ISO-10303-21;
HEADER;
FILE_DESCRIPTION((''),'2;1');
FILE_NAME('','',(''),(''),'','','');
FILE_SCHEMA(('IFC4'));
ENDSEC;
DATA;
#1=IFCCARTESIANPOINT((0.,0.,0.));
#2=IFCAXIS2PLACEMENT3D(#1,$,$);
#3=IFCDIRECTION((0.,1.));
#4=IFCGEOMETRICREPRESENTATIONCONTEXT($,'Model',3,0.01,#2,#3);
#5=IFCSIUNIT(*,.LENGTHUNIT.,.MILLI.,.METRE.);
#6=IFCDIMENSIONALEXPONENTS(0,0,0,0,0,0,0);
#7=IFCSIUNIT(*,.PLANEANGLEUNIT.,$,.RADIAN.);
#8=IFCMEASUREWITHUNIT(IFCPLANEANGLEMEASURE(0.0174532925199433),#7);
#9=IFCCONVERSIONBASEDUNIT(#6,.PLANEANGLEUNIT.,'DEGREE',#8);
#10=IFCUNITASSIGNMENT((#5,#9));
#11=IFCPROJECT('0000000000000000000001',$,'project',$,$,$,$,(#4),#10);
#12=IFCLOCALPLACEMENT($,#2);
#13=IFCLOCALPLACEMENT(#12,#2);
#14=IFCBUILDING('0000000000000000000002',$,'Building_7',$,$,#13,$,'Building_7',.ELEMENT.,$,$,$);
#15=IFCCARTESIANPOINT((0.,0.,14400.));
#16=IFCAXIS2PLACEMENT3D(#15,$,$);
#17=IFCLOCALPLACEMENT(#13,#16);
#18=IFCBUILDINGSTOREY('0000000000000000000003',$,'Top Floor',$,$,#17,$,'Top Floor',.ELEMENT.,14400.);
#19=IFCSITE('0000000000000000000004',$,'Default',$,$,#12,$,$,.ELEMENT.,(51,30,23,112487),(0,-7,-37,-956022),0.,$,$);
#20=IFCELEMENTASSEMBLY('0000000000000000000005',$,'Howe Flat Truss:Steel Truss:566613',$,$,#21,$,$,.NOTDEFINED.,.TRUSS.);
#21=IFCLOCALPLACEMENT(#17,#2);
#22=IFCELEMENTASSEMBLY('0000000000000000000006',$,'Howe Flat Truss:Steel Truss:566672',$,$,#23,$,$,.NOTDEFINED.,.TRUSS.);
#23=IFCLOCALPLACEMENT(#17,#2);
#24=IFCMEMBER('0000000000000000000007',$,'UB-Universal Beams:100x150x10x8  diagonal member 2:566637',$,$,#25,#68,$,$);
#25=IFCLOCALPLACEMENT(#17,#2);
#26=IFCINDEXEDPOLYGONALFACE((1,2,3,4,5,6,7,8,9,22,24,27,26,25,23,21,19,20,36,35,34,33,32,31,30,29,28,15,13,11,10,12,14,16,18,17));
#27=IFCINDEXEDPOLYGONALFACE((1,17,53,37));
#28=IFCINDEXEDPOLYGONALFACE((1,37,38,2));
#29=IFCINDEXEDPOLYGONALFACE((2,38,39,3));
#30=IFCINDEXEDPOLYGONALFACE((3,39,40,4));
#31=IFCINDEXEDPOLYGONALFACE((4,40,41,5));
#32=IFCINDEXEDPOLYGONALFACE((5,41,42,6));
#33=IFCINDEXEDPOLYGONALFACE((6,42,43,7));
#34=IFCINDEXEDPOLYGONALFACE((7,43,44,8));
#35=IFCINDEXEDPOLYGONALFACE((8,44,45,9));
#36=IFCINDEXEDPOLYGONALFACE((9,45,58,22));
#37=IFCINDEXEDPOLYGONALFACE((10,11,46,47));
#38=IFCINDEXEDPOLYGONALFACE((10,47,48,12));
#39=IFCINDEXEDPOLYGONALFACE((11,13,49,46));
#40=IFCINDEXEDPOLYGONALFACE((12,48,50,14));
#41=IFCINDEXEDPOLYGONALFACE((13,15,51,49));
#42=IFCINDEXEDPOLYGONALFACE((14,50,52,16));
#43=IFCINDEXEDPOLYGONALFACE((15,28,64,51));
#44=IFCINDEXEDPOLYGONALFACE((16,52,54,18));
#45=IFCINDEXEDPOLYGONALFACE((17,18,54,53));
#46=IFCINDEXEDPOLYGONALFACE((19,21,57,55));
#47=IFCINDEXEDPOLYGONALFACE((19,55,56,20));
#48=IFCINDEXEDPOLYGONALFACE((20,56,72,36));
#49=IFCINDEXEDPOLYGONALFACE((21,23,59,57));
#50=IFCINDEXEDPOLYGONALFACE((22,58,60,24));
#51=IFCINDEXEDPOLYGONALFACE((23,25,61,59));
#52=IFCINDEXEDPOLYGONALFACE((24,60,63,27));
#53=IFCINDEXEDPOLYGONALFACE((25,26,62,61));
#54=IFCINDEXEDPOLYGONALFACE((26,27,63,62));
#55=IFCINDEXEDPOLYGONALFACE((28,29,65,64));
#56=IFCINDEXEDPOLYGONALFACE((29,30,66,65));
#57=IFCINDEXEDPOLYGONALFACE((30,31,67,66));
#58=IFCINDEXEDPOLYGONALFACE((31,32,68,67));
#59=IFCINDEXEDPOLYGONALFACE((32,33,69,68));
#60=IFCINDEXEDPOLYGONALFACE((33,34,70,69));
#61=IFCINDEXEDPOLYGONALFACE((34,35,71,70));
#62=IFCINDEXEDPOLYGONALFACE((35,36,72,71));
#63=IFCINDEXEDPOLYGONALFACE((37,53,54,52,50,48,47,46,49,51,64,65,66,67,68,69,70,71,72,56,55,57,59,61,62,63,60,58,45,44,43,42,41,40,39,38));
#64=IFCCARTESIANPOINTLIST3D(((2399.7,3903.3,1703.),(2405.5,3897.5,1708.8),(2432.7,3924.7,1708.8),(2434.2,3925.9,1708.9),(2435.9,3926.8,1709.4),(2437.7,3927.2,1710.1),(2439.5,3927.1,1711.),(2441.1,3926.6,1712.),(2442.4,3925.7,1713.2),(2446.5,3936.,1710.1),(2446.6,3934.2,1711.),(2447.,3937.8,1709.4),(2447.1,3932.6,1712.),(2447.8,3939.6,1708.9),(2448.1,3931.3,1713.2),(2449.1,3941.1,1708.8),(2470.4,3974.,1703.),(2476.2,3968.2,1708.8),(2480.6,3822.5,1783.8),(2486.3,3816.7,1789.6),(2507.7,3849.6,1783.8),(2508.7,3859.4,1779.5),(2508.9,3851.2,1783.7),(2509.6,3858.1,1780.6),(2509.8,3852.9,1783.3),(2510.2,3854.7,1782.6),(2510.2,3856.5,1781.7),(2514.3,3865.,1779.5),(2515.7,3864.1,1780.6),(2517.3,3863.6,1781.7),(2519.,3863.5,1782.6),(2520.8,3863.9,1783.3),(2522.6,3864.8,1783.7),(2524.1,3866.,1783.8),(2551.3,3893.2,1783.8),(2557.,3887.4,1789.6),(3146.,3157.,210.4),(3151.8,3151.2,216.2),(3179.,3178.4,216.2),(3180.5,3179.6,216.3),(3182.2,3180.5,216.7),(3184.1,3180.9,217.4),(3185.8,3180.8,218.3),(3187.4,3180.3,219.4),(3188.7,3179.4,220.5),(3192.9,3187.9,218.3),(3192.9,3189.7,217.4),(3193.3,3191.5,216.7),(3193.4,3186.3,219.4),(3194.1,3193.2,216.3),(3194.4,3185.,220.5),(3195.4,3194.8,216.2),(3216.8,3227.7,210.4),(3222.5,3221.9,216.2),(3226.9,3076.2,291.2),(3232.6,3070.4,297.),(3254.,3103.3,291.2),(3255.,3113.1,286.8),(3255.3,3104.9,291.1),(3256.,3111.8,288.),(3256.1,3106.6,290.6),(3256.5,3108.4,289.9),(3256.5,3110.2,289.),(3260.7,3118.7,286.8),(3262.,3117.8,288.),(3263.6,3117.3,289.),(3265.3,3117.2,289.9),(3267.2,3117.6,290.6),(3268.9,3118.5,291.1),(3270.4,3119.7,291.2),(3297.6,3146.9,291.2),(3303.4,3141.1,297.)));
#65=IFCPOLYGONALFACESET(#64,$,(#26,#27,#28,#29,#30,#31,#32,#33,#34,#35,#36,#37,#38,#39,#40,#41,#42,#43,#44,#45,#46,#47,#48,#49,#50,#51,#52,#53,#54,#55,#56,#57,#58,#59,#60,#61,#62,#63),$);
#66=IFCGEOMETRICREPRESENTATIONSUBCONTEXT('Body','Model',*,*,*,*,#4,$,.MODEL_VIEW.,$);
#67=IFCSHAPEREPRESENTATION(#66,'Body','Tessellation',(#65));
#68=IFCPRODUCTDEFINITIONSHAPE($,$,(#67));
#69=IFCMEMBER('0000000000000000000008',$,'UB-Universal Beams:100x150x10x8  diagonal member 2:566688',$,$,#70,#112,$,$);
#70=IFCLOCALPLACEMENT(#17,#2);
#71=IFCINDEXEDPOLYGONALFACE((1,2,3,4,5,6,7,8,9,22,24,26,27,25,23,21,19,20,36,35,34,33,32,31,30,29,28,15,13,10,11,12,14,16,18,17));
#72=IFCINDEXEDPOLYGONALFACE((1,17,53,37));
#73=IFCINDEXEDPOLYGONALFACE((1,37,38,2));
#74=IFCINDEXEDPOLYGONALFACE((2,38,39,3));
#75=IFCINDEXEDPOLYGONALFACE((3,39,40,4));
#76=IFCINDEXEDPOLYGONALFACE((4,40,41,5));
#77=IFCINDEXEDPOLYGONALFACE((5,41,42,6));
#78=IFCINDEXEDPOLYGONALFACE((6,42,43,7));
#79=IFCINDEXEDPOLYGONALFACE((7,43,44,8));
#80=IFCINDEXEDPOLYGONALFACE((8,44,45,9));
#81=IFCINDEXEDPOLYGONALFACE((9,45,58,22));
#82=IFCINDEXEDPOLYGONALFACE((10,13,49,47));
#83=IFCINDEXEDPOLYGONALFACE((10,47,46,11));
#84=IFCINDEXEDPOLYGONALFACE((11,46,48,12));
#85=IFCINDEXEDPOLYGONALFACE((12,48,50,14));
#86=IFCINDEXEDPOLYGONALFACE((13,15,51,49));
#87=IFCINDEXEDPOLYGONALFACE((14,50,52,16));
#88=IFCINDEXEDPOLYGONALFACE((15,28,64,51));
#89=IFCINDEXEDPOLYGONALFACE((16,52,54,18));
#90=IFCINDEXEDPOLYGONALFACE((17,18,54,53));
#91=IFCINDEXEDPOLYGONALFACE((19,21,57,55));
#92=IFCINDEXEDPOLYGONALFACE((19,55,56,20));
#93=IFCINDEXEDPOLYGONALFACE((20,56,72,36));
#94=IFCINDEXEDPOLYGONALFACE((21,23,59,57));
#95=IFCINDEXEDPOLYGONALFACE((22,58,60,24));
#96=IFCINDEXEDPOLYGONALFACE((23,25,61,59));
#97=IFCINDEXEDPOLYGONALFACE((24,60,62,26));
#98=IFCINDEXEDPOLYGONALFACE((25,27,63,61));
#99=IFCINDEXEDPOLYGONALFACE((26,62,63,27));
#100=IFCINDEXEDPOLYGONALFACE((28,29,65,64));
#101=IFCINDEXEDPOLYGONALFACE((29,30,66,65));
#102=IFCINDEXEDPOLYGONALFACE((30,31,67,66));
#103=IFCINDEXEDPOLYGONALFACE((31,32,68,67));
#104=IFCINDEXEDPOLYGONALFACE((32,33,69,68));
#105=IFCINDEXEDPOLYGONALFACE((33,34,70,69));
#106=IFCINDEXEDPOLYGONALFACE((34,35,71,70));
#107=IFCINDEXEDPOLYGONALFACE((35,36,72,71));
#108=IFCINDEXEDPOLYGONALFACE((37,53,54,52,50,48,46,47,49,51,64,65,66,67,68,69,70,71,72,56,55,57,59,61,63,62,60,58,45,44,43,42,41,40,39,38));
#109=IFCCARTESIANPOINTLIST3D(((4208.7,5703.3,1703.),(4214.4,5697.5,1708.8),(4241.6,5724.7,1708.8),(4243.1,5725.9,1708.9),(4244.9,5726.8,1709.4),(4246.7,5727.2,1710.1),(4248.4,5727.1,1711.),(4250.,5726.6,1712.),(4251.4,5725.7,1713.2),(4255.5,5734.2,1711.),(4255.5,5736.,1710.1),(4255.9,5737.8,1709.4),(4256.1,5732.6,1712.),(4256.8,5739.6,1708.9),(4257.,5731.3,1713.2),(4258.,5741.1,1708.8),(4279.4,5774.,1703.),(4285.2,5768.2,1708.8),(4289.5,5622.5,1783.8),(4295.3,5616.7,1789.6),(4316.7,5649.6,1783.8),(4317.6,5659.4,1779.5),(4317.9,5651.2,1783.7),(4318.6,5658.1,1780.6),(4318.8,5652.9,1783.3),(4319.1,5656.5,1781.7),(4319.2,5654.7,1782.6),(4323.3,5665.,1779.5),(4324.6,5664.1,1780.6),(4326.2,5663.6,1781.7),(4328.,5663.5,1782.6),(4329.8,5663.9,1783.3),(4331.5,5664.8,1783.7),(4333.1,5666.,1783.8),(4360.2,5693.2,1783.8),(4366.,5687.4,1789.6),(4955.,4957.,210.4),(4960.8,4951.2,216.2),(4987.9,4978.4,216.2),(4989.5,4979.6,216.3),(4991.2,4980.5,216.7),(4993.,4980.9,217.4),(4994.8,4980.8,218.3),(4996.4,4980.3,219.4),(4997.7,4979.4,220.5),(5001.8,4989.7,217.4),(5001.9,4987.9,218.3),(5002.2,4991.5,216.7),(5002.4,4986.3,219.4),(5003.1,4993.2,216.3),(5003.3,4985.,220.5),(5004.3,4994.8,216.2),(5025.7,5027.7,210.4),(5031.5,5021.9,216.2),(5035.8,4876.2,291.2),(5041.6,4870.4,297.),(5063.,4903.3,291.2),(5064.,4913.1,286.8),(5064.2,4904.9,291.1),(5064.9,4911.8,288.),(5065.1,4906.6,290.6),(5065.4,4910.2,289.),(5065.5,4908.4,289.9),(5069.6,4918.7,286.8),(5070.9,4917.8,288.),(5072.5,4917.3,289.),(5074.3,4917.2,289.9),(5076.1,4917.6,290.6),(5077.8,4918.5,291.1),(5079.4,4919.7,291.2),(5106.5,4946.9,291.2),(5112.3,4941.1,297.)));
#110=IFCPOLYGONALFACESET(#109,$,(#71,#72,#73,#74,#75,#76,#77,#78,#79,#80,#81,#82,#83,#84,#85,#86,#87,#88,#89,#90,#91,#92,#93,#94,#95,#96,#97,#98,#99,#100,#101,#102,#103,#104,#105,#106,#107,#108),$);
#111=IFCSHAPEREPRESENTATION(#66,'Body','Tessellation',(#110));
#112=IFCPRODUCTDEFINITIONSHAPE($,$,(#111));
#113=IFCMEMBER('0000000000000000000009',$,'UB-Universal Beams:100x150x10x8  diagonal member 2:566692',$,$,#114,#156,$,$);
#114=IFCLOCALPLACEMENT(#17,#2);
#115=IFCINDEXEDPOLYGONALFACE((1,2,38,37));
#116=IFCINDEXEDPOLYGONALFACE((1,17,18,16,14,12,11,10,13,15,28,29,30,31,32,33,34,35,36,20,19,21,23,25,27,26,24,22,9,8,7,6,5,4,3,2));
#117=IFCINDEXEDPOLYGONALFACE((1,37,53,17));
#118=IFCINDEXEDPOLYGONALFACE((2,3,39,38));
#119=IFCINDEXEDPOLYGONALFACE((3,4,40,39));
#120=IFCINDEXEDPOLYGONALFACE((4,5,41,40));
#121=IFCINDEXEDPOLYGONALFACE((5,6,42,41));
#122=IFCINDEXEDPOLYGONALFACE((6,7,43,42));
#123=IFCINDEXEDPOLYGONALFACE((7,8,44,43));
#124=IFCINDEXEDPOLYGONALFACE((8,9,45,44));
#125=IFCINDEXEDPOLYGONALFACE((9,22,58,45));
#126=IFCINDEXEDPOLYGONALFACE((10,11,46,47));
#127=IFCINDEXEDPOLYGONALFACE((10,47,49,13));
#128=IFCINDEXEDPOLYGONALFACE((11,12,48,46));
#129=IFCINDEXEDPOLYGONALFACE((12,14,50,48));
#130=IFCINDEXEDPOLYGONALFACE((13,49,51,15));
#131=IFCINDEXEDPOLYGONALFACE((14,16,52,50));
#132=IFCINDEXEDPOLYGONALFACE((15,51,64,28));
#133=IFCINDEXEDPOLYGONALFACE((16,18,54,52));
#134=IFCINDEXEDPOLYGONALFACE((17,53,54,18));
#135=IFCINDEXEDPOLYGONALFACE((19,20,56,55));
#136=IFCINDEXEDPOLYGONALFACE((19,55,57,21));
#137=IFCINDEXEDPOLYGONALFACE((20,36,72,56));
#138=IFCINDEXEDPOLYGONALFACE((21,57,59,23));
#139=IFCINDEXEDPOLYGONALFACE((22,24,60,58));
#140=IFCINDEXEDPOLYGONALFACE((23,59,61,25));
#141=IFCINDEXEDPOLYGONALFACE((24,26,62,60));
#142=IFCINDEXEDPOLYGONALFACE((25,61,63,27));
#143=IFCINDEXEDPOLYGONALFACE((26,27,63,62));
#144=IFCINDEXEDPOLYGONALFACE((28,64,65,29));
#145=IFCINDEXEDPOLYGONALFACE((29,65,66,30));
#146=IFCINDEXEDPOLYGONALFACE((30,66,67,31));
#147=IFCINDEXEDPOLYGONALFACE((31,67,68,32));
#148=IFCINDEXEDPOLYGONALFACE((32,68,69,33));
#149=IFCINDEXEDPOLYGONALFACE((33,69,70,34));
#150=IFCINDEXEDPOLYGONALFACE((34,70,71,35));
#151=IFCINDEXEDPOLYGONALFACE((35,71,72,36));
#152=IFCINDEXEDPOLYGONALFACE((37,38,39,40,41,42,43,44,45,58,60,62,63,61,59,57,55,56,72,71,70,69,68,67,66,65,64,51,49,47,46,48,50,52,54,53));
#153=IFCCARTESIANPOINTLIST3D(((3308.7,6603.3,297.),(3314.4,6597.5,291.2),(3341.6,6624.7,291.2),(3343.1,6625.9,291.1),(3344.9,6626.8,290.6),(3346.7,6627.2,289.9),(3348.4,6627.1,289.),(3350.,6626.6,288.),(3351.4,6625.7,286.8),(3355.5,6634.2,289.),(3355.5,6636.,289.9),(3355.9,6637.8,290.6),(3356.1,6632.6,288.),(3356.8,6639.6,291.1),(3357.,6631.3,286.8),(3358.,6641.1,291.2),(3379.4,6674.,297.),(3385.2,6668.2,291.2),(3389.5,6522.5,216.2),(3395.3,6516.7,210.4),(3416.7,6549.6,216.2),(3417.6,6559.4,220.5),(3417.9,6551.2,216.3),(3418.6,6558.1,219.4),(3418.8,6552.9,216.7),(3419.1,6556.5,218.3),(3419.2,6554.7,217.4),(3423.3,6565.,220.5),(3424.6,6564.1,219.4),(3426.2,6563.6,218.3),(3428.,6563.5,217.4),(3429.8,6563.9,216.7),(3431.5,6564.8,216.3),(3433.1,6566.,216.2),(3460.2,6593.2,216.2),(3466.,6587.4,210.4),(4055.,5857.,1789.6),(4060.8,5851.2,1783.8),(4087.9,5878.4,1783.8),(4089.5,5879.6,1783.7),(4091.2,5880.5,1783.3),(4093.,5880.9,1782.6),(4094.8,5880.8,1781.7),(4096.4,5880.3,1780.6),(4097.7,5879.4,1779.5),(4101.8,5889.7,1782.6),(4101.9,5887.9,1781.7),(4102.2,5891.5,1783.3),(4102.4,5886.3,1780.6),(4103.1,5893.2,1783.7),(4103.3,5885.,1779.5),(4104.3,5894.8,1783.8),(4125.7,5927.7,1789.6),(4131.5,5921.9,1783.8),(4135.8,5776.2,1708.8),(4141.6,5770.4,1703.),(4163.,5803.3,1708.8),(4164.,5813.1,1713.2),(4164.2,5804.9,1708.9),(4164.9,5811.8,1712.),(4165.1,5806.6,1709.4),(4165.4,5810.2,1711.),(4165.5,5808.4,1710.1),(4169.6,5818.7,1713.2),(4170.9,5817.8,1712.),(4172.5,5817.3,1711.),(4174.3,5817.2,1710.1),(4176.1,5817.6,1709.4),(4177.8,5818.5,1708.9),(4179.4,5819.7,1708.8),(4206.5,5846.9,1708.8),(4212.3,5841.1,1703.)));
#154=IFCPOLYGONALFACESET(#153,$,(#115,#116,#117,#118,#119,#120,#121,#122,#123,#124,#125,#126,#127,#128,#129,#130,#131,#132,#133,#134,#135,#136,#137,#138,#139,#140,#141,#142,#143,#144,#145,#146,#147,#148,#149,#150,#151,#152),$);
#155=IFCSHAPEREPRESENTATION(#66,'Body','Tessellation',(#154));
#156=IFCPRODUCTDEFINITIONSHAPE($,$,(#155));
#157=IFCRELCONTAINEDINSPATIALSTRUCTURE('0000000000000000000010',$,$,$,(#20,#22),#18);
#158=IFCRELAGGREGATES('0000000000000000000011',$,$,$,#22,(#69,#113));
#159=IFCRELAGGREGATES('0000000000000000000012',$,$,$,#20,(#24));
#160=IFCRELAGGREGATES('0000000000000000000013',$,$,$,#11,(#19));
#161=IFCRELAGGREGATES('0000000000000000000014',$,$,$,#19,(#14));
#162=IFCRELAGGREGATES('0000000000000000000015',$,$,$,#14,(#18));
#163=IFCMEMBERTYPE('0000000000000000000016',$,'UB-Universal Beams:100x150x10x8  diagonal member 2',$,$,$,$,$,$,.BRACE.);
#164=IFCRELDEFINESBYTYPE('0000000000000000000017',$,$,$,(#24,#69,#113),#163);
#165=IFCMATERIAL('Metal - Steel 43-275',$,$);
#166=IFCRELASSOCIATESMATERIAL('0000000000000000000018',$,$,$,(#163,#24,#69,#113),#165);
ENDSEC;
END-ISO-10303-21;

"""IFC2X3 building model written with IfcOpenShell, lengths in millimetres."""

from ifc_helpers import new_model, entity, si_unit, converted_unit, direction, frame, frame_2d, origin, place, context, subcontext, project, spatial, polyline, circle_curve, parameter, trimmed, segment, composite_curve, outline, extrude, source, transform, mapped, material, type_object, type_shapes, element, aggregate, save


model = new_model("IFC2X3")

# Units and contexts
model_context = context("Model", 3, precision=0.01, world=origin(), true_north=direction((0.0, 1.0)))
body_context = subcontext(model_context, "Body", "Model", "MODEL_VIEW")
ifc_project = project(units=[si_unit("LENGTHUNIT", "METRE", prefix="MILLI"), converted_unit("PLANEANGLEUNIT", "DEGREE", entity("IfcPlaneAngleMeasure", 0.0174532925199433), si_unit("PLANEANGLEUNIT", "RADIAN"), dimensions=[0, 0, 0, 0, 0, 0, 0])], contexts=[model_context])

# Site, building, storey
site_placement = place(None, origin())
site = spatial("IfcSite", under=ifc_project, at=site_placement, Name="Default", CompositionType="ELEMENT", RefLatitude=(51, 30, 23, 112487), RefLongitude=(0, -7, -37, -956022), RefElevation=0.0)
building_placement = place(site_placement, origin())
building = spatial("IfcBuilding", under=site, at=building_placement, Name="Building_7", LongName="Building_7", CompositionType="ELEMENT")
storey_placement = place(building_placement, frame((0.0, 0.0, 14400.0)))
storey = spatial("IfcBuildingStorey", under=building, at=storey_placement, Name="Top Floor", LongName="Top Floor", CompositionType="ELEMENT", Elevation=14400.0)

# Shared definitions
ifc_material = material(Name="Metal - Steel 43-275")

# Element assemblies
assembly_1_placement = place(storey_placement, origin())
assembly_1 = element("IfcElementAssembly", 1, at=assembly_1_placement, inside=storey, Name="Howe Flat Truss:Steel Truss:566613", AssemblyPlace="NOTDEFINED", PredefinedType="TRUSS")
assembly_2_placement = place(storey_placement, origin())
assembly_2 = element("IfcElementAssembly", 2, at=assembly_2_placement, inside=storey, Name="Howe Flat Truss:Steel Truss:566672", AssemblyPlace="NOTDEFINED", PredefinedType="TRUSS")

# Members
member_type_1 = type_object("IfcMemberType", Name="UB-Universal Beams:100x150x10x8  diagonal member 2", PredefinedType="BRACE", material=ifc_material)
shared_shape_1 = source(origin(), body_context, "Body", "SweptSolid", [
    extrude(outline(composite_curve([segment(polyline([(-50.0, -65.0), (-50.0, -75.0)]), True, "CONTINUOUS"), segment(polyline([(-50.0, -75.0), (50.0, -75.0)]), True, "CONTINUOUS"), segment(polyline([(50.0, -75.0), (50.0, -65.0)]), True, "CONTINUOUS"), segment(polyline([(50.0, -65.0), (11.6, -65.0)]), True, "CONTINUOUS"), segment(trimmed(circle_curve(frame_2d((11.6, -57.4), x_axis=(1.0, 0.0)), 7.6), [parameter(180.0)], [parameter(270.0)], True, "PARAMETER"), False, "CONTINUOUS"), segment(polyline([(4.0, -57.4), (4.0, 57.4)]), True, "CONTINUOUS"), segment(trimmed(circle_curve(frame_2d((11.6, 57.4), x_axis=(1.0, 0.0)), 7.6), [parameter(90.0)], [parameter(180.0)], True, "PARAMETER"), False, "CONTINUOUS"), segment(polyline([(11.6, 65.0), (50.0, 65.0)]), True, "CONTINUOUS"), segment(polyline([(50.0, 65.0), (50.0, 75.0)]), True, "CONTINUOUS"), segment(polyline([(50.0, 75.0), (-50.0, 75.0)]), True, "CONTINUOUS"), segment(polyline([(-50.0, 75.0), (-50.0, 65.0)]), True, "CONTINUOUS"), segment(polyline([(-50.0, 65.0), (-11.6, 65.0)]), True, "CONTINUOUS"), segment(trimmed(circle_curve(frame_2d((-11.6, 57.4), x_axis=(1.0, 0.0)), 7.6), [parameter(360.0)], [parameter(90.0)], True, "PARAMETER"), False, "CONTINUOUS"), segment(polyline([(-4.0, 57.4), (-4.0, -57.4)]), True, "CONTINUOUS"), segment(trimmed(circle_curve(frame_2d((-11.6, -57.4), x_axis=(1.0, 0.0)), 7.6), [parameter(270.0)], [parameter(360.0)], True, "PARAMETER"), False, "CONTINUOUS"), segment(polyline([(-11.6, -65.0), (-50.0, -65.0)]), True, "CONTINUOUS")], self_intersect=False)), frame((-914.0, 0.0, 0.0), z_axis=(-1.0, 0.0, 0.0), x_axis=(0.0, -1.0, 0.0)), (0.0, 0.0, -1.0), 1828.1),
])
type_shapes(member_type_1, [shared_shape_1])
member_1_placement = place(assembly_1_placement, frame((2851.5, 3522.2, 1000.0), z_axis=(-0.57735, 0.57735, -0.57735), x_axis=(0.408248, -0.408248, -0.816497)))
member_1 = element("IfcMember", 3, at=member_1_placement, type_object=member_type_1, material=ifc_material, Name="UB-Universal Beams:100x150x10x8  diagonal member 2:566637", context=body_context, shape_type="MappedRepresentation", body=[
    mapped(shared_shape_1, transform((0.0, 0.0, 0.0), scale=1.0)),
])
member_2_placement = place(assembly_2_placement, frame((4660.5, 5322.2, 1000.0), z_axis=(-0.57735, 0.57735, -0.57735), x_axis=(-0.408248, 0.408248, 0.816497)))
member_2 = element("IfcMember", 4, at=member_2_placement, type_object=member_type_1, material=ifc_material, Name="UB-Universal Beams:100x150x10x8  diagonal member 2:566688", context=body_context, shape_type="MappedRepresentation", body=[
    mapped(shared_shape_1, transform((0.0, 0.0, 0.0), scale=1.0)),
])
member_3_placement = place(assembly_2_placement, frame((3760.5, 6222.2, 1000.0), z_axis=(0.57735, -0.57735, -0.57735), x_axis=(-0.408248, 0.408248, -0.816497)))
member_3 = element("IfcMember", 5, at=member_3_placement, type_object=member_type_1, material=ifc_material, Name="UB-Universal Beams:100x150x10x8  diagonal member 2:566692", context=body_context, shape_type="MappedRepresentation", body=[
    mapped(shared_shape_1, transform((0.0, 0.0, 0.0), scale=1.0)),
])
aggregate(assembly_2, [member_2, member_3])
aggregate(assembly_1, [member_1])

save(model, "model.ifc")
